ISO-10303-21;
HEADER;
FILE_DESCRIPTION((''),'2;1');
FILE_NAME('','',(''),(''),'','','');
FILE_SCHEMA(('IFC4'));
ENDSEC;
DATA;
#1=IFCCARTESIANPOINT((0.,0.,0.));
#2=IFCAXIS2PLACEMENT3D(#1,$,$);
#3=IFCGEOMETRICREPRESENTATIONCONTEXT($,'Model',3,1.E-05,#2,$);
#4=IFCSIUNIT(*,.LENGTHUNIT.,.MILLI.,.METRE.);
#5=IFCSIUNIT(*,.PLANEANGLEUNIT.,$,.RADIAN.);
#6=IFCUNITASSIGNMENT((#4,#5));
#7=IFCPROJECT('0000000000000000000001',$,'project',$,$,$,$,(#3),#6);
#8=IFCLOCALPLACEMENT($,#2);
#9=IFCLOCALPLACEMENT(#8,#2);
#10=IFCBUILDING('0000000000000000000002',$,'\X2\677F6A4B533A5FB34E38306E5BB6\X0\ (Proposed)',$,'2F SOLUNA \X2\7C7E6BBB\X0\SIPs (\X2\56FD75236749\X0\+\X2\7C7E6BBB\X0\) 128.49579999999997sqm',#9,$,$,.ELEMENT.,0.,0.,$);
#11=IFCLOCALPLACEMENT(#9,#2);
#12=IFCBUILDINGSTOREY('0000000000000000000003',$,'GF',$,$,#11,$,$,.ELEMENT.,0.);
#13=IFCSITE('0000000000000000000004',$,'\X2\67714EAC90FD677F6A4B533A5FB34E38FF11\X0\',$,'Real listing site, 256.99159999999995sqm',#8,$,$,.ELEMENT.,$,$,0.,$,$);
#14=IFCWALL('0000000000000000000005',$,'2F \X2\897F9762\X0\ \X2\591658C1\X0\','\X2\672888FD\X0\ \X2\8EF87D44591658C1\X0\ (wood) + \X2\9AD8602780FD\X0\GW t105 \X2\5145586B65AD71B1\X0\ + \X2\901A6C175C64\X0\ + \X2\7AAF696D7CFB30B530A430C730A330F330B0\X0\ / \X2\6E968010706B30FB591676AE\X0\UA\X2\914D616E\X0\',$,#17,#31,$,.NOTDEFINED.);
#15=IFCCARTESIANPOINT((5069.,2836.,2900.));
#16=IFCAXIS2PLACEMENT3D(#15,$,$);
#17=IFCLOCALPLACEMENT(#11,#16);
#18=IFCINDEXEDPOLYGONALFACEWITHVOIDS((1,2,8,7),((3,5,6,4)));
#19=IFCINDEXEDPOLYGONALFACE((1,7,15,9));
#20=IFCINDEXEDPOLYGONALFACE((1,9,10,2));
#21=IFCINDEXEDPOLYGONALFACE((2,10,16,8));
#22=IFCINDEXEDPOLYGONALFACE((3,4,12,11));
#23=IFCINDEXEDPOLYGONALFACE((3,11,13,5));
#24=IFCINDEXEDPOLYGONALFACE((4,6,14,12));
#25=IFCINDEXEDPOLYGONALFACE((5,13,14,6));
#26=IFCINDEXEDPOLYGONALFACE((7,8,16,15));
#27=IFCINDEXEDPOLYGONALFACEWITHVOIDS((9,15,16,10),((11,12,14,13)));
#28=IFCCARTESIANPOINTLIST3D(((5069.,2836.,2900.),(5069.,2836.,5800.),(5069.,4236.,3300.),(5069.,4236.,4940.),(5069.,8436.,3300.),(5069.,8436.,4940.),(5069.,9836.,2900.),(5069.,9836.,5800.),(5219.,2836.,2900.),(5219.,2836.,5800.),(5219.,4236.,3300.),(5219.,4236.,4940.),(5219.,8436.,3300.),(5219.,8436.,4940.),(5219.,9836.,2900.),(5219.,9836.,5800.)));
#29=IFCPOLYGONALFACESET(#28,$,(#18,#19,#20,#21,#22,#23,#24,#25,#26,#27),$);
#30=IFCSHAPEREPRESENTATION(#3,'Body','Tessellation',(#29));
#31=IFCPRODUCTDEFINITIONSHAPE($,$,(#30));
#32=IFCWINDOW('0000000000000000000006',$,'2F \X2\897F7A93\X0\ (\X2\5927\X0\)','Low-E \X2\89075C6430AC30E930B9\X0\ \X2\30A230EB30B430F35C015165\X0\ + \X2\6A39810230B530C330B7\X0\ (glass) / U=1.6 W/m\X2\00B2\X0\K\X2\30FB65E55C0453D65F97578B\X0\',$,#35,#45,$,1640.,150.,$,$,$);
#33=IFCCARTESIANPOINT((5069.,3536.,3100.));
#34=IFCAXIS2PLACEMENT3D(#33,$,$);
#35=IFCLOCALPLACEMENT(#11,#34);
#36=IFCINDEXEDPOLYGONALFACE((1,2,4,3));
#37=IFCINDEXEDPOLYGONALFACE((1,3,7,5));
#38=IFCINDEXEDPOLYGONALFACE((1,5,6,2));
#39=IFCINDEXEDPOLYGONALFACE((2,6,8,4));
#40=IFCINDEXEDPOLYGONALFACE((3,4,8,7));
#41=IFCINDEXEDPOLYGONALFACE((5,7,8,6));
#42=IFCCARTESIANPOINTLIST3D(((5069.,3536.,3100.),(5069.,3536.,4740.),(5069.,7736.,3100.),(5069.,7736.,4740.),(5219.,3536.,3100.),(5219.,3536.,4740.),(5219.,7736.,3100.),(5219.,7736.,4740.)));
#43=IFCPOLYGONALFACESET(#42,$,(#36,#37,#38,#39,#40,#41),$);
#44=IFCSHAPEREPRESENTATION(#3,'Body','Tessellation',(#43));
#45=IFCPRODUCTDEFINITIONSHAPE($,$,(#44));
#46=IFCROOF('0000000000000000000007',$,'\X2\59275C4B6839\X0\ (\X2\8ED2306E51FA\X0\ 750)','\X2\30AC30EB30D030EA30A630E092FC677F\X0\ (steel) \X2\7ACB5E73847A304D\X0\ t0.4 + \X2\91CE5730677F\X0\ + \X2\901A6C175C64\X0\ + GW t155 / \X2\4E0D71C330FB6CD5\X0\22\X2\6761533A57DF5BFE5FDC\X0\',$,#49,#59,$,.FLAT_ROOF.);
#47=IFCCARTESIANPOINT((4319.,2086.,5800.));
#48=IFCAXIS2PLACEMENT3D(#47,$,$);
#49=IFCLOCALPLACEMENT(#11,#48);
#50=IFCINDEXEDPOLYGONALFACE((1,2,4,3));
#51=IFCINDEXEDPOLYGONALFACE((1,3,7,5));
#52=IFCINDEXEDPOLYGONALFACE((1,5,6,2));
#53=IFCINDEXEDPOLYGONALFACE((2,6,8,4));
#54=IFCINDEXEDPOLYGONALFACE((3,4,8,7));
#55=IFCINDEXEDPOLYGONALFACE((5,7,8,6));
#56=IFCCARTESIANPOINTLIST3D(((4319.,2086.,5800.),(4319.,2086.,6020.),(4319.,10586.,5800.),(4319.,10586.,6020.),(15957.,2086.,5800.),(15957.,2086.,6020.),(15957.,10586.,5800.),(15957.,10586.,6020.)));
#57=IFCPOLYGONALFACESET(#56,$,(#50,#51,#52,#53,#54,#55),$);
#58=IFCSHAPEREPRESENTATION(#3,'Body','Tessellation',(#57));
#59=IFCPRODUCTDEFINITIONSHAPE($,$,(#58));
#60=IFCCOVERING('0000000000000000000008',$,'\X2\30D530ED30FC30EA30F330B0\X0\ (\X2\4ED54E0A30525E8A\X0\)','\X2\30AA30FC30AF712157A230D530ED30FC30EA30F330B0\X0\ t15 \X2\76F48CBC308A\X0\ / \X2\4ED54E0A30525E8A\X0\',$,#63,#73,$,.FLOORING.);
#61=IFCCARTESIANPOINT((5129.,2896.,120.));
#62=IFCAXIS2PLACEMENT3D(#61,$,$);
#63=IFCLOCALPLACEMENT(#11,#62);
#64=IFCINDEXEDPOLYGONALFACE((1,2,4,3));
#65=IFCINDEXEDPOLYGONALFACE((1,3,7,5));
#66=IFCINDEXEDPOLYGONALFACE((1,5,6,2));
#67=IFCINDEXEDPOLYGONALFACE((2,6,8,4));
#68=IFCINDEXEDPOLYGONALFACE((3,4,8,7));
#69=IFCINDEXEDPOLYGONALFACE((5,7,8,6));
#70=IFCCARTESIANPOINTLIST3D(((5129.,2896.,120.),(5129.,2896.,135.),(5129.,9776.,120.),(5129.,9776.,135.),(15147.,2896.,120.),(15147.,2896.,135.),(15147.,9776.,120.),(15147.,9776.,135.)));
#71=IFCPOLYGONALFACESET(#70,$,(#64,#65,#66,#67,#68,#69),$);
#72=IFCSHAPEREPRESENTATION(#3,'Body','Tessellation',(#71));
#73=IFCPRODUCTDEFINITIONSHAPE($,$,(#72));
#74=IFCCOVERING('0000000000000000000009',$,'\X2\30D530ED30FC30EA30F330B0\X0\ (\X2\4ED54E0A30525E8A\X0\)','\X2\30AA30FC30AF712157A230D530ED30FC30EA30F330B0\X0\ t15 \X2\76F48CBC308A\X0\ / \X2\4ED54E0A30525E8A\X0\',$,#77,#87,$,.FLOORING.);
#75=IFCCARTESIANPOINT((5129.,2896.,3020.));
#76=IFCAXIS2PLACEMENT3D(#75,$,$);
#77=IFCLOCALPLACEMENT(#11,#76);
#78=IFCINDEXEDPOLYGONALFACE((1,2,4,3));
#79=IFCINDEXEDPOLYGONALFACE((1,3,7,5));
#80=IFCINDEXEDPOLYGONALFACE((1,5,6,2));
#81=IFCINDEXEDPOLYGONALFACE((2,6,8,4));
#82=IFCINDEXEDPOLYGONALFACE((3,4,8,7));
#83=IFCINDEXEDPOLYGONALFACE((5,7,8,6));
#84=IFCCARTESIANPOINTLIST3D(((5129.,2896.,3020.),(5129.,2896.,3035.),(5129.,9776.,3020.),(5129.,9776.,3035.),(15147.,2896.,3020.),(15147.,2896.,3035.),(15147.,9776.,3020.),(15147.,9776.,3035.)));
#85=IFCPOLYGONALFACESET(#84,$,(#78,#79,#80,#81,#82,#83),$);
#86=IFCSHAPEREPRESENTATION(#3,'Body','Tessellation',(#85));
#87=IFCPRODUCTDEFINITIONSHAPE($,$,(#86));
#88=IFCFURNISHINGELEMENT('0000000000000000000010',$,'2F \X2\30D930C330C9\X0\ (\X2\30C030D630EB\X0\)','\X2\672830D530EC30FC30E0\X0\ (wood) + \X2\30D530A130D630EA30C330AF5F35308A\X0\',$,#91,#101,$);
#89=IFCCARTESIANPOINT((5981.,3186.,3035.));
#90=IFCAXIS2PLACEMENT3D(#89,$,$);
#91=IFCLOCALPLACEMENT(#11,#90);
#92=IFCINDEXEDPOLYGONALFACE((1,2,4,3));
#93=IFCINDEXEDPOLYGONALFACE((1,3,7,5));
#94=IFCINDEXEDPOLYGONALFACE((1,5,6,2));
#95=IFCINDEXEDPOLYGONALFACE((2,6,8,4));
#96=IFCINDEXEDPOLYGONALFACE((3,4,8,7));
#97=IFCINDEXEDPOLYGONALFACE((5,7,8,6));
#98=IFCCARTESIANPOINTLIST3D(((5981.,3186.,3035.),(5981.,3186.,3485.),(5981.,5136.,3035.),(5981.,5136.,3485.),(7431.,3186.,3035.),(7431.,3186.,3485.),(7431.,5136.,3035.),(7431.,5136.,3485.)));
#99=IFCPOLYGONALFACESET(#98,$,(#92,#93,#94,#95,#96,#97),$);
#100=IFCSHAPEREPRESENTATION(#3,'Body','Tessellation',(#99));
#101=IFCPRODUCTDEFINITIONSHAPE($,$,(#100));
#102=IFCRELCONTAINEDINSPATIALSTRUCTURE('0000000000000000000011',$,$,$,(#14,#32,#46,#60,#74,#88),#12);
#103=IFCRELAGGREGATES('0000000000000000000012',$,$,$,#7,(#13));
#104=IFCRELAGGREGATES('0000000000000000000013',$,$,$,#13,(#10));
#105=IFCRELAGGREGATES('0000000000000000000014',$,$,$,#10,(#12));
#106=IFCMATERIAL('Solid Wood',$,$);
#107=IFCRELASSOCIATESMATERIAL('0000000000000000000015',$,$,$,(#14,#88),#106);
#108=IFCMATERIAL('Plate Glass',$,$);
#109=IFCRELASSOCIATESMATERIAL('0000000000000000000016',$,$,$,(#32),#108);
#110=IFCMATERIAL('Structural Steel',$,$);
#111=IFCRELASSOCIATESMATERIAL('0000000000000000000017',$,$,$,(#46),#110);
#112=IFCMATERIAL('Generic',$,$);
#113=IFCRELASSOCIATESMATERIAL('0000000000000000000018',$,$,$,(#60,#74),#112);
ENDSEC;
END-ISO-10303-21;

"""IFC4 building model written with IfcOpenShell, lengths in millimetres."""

from ifc_helpers import new_model, si_unit, frame, frame_2d, origin, place, context, project, spatial, rectangle, extrude, material, element, fill, save


model = new_model("IFC4")

# Units and contexts
model_context = context("Model", 3, precision=1e-05, world=origin())
ifc_project = project(units=[si_unit("LENGTHUNIT", "METRE", prefix="MILLI"), si_unit("PLANEANGLEUNIT", "RADIAN")], contexts=[model_context])

# Site, building, storey
site_placement = place(None, origin())
site = spatial("IfcSite", under=ifc_project, at=site_placement, Name="東京都板橋区徳丸１", ObjectType="Real listing site, 256.99159999999995sqm", CompositionType="ELEMENT", RefElevation=0.0)
building_placement = place(site_placement, origin())
building = spatial("IfcBuilding", under=site, at=building_placement, Name="板橋区徳丸の家 (Proposed)", ObjectType="2F SOLUNA 籾殻SIPs (国産杉+籾殻) 128.49579999999997sqm", CompositionType="ELEMENT", ElevationOfRefHeight=0.0, ElevationOfTerrain=0.0)
storey_placement = place(building_placement, origin())
storey = spatial("IfcBuildingStorey", under=building, at=storey_placement, Name="GF", CompositionType="ELEMENT", Elevation=0.0)

# Shared definitions
ifc_material_1 = material(Name="Solid Wood")

# Shared definitions
ifc_material_2 = material(Name="Plate Glass")

# Wall, opening, window
wall_1_placement = place(storey_placement, frame((5069.0, 2836.0, 2900.0)))
wall_1 = element("IfcWall", 1, at=wall_1_placement, inside=storey, material=ifc_material_1, Name="2F 西面 外壁", Description="木製 軸組外壁 (wood) + 高性能GW t105 充填断熱 + 通気層 + 窯業系サイディング / 準耐火・外皮UA配慮", PredefinedType="NOTDEFINED", context=model_context, shape_type="SweptSolid", body=[
    extrude(rectangle(XDim=150.0, YDim=7000.0, at=frame_2d((75.0, 3500.0))), frame((5069.0, 2836.0, 2900.0)), (0.0, 0.0, 1.0), 2900.0),
])
opening_1_placement = place(storey_placement, frame((5069.0, 3536.0, 3100.0)))
opening_1 = element("IfcOpeningElement", 2, at=opening_1_placement, cuts=wall_1, PredefinedType="NOTDEFINED", context=model_context, shape_type="SweptSolid", body=[
    extrude(rectangle(XDim=150.0, YDim=4200.0, at=frame_2d((75.0, 2100.0))), frame((5069.0, 3536.0, 3100.0)), (0.0, 0.0, 1.0), 1640.0),
])
window_1_placement = place(storey_placement, frame((5069.0, 3536.0, 3100.0)))
window_1 = element("IfcWindow", 3, at=window_1_placement, inside=storey, material=ifc_material_2, Name="2F 西窓 (大)", Description="Low-E 複層ガラス アルゴン封入 + 樹脂サッシ (glass) / U=1.6 W/m²K・日射取得型", OverallHeight=1640.0, OverallWidth=150.0, context=model_context, shape_type="SweptSolid", body=[
    extrude(rectangle(XDim=150.0, YDim=4200.0, at=frame_2d((75.0, 2100.0))), frame((5069.0, 3536.0, 3100.0)), (0.0, 0.0, 1.0), 1640.0),
])
fill(opening_1, window_1)

# Roof
ifc_material_3 = material(Name="Structural Steel")
roof_placement = place(storey_placement, frame((4319.0, 2086.0, 5800.0)))
element("IfcRoof", 4, at=roof_placement, inside=storey, material=ifc_material_3, Name="大屋根 (軒の出 750)", Description="ガルバリウム鋼板 (steel) 立平葺き t0.4 + 野地板 + 通気層 + GW t155 / 不燃・法22条区域対応", PredefinedType="FLAT_ROOF", context=model_context, shape_type="SweptSolid", body=[
    extrude(rectangle(XDim=11638.0, YDim=8500.0, at=frame_2d((5819.0, 4250.0))), frame((4319.0, 2086.0, 5800.0)), (0.0, 0.0, 1.0), 220.0),
])

# Coverings
ifc_material_4 = material(Name="Generic")
covering_1_placement = place(storey_placement, frame((5129.0, 2896.0, 120.0)))
element("IfcCovering", 5, at=covering_1_placement, inside=storey, material=ifc_material_4, Name="フローリング (仕上げ床)", Description="オーク無垢フローリング t15 直貼り / 仕上げ床", PredefinedType="FLOORING", context=model_context, shape_type="SweptSolid", body=[
    extrude(rectangle(XDim=10018.0, YDim=6880.0, at=frame_2d((5009.0, 3440.0))), frame((5129.0, 2896.0, 120.0)), (0.0, 0.0, 1.0), 15.0),
])
covering_2_placement = place(storey_placement, frame((5129.0, 2896.0, 3020.0)))
element("IfcCovering", 6, at=covering_2_placement, inside=storey, material=ifc_material_4, Name="フローリング (仕上げ床)", Description="オーク無垢フローリング t15 直貼り / 仕上げ床", PredefinedType="FLOORING", context=model_context, shape_type="SweptSolid", body=[
    extrude(rectangle(XDim=10018.0, YDim=6880.0, at=frame_2d((5009.0, 3440.0))), frame((5129.0, 2896.0, 3020.0)), (0.0, 0.0, 1.0), 15.0),
])

# Furnishing element
furnishing_placement = place(storey_placement, frame((5981.0, 3186.0, 3035.0)))
element("IfcFurnishingElement", 7, at=furnishing_placement, inside=storey, material=ifc_material_1, Name="2F ベッド (ダブル)", Description="木フレーム (wood) + ファブリック張り", context=model_context, shape_type="SweptSolid", body=[
    extrude(rectangle(XDim=1450.0, YDim=1950.0, at=frame_2d((725.0, 975.0))), frame((5981.0, 3186.0, 3035.0)), (0.0, 0.0, 1.0), 450.0),
])

save(model, "model.ifc")
